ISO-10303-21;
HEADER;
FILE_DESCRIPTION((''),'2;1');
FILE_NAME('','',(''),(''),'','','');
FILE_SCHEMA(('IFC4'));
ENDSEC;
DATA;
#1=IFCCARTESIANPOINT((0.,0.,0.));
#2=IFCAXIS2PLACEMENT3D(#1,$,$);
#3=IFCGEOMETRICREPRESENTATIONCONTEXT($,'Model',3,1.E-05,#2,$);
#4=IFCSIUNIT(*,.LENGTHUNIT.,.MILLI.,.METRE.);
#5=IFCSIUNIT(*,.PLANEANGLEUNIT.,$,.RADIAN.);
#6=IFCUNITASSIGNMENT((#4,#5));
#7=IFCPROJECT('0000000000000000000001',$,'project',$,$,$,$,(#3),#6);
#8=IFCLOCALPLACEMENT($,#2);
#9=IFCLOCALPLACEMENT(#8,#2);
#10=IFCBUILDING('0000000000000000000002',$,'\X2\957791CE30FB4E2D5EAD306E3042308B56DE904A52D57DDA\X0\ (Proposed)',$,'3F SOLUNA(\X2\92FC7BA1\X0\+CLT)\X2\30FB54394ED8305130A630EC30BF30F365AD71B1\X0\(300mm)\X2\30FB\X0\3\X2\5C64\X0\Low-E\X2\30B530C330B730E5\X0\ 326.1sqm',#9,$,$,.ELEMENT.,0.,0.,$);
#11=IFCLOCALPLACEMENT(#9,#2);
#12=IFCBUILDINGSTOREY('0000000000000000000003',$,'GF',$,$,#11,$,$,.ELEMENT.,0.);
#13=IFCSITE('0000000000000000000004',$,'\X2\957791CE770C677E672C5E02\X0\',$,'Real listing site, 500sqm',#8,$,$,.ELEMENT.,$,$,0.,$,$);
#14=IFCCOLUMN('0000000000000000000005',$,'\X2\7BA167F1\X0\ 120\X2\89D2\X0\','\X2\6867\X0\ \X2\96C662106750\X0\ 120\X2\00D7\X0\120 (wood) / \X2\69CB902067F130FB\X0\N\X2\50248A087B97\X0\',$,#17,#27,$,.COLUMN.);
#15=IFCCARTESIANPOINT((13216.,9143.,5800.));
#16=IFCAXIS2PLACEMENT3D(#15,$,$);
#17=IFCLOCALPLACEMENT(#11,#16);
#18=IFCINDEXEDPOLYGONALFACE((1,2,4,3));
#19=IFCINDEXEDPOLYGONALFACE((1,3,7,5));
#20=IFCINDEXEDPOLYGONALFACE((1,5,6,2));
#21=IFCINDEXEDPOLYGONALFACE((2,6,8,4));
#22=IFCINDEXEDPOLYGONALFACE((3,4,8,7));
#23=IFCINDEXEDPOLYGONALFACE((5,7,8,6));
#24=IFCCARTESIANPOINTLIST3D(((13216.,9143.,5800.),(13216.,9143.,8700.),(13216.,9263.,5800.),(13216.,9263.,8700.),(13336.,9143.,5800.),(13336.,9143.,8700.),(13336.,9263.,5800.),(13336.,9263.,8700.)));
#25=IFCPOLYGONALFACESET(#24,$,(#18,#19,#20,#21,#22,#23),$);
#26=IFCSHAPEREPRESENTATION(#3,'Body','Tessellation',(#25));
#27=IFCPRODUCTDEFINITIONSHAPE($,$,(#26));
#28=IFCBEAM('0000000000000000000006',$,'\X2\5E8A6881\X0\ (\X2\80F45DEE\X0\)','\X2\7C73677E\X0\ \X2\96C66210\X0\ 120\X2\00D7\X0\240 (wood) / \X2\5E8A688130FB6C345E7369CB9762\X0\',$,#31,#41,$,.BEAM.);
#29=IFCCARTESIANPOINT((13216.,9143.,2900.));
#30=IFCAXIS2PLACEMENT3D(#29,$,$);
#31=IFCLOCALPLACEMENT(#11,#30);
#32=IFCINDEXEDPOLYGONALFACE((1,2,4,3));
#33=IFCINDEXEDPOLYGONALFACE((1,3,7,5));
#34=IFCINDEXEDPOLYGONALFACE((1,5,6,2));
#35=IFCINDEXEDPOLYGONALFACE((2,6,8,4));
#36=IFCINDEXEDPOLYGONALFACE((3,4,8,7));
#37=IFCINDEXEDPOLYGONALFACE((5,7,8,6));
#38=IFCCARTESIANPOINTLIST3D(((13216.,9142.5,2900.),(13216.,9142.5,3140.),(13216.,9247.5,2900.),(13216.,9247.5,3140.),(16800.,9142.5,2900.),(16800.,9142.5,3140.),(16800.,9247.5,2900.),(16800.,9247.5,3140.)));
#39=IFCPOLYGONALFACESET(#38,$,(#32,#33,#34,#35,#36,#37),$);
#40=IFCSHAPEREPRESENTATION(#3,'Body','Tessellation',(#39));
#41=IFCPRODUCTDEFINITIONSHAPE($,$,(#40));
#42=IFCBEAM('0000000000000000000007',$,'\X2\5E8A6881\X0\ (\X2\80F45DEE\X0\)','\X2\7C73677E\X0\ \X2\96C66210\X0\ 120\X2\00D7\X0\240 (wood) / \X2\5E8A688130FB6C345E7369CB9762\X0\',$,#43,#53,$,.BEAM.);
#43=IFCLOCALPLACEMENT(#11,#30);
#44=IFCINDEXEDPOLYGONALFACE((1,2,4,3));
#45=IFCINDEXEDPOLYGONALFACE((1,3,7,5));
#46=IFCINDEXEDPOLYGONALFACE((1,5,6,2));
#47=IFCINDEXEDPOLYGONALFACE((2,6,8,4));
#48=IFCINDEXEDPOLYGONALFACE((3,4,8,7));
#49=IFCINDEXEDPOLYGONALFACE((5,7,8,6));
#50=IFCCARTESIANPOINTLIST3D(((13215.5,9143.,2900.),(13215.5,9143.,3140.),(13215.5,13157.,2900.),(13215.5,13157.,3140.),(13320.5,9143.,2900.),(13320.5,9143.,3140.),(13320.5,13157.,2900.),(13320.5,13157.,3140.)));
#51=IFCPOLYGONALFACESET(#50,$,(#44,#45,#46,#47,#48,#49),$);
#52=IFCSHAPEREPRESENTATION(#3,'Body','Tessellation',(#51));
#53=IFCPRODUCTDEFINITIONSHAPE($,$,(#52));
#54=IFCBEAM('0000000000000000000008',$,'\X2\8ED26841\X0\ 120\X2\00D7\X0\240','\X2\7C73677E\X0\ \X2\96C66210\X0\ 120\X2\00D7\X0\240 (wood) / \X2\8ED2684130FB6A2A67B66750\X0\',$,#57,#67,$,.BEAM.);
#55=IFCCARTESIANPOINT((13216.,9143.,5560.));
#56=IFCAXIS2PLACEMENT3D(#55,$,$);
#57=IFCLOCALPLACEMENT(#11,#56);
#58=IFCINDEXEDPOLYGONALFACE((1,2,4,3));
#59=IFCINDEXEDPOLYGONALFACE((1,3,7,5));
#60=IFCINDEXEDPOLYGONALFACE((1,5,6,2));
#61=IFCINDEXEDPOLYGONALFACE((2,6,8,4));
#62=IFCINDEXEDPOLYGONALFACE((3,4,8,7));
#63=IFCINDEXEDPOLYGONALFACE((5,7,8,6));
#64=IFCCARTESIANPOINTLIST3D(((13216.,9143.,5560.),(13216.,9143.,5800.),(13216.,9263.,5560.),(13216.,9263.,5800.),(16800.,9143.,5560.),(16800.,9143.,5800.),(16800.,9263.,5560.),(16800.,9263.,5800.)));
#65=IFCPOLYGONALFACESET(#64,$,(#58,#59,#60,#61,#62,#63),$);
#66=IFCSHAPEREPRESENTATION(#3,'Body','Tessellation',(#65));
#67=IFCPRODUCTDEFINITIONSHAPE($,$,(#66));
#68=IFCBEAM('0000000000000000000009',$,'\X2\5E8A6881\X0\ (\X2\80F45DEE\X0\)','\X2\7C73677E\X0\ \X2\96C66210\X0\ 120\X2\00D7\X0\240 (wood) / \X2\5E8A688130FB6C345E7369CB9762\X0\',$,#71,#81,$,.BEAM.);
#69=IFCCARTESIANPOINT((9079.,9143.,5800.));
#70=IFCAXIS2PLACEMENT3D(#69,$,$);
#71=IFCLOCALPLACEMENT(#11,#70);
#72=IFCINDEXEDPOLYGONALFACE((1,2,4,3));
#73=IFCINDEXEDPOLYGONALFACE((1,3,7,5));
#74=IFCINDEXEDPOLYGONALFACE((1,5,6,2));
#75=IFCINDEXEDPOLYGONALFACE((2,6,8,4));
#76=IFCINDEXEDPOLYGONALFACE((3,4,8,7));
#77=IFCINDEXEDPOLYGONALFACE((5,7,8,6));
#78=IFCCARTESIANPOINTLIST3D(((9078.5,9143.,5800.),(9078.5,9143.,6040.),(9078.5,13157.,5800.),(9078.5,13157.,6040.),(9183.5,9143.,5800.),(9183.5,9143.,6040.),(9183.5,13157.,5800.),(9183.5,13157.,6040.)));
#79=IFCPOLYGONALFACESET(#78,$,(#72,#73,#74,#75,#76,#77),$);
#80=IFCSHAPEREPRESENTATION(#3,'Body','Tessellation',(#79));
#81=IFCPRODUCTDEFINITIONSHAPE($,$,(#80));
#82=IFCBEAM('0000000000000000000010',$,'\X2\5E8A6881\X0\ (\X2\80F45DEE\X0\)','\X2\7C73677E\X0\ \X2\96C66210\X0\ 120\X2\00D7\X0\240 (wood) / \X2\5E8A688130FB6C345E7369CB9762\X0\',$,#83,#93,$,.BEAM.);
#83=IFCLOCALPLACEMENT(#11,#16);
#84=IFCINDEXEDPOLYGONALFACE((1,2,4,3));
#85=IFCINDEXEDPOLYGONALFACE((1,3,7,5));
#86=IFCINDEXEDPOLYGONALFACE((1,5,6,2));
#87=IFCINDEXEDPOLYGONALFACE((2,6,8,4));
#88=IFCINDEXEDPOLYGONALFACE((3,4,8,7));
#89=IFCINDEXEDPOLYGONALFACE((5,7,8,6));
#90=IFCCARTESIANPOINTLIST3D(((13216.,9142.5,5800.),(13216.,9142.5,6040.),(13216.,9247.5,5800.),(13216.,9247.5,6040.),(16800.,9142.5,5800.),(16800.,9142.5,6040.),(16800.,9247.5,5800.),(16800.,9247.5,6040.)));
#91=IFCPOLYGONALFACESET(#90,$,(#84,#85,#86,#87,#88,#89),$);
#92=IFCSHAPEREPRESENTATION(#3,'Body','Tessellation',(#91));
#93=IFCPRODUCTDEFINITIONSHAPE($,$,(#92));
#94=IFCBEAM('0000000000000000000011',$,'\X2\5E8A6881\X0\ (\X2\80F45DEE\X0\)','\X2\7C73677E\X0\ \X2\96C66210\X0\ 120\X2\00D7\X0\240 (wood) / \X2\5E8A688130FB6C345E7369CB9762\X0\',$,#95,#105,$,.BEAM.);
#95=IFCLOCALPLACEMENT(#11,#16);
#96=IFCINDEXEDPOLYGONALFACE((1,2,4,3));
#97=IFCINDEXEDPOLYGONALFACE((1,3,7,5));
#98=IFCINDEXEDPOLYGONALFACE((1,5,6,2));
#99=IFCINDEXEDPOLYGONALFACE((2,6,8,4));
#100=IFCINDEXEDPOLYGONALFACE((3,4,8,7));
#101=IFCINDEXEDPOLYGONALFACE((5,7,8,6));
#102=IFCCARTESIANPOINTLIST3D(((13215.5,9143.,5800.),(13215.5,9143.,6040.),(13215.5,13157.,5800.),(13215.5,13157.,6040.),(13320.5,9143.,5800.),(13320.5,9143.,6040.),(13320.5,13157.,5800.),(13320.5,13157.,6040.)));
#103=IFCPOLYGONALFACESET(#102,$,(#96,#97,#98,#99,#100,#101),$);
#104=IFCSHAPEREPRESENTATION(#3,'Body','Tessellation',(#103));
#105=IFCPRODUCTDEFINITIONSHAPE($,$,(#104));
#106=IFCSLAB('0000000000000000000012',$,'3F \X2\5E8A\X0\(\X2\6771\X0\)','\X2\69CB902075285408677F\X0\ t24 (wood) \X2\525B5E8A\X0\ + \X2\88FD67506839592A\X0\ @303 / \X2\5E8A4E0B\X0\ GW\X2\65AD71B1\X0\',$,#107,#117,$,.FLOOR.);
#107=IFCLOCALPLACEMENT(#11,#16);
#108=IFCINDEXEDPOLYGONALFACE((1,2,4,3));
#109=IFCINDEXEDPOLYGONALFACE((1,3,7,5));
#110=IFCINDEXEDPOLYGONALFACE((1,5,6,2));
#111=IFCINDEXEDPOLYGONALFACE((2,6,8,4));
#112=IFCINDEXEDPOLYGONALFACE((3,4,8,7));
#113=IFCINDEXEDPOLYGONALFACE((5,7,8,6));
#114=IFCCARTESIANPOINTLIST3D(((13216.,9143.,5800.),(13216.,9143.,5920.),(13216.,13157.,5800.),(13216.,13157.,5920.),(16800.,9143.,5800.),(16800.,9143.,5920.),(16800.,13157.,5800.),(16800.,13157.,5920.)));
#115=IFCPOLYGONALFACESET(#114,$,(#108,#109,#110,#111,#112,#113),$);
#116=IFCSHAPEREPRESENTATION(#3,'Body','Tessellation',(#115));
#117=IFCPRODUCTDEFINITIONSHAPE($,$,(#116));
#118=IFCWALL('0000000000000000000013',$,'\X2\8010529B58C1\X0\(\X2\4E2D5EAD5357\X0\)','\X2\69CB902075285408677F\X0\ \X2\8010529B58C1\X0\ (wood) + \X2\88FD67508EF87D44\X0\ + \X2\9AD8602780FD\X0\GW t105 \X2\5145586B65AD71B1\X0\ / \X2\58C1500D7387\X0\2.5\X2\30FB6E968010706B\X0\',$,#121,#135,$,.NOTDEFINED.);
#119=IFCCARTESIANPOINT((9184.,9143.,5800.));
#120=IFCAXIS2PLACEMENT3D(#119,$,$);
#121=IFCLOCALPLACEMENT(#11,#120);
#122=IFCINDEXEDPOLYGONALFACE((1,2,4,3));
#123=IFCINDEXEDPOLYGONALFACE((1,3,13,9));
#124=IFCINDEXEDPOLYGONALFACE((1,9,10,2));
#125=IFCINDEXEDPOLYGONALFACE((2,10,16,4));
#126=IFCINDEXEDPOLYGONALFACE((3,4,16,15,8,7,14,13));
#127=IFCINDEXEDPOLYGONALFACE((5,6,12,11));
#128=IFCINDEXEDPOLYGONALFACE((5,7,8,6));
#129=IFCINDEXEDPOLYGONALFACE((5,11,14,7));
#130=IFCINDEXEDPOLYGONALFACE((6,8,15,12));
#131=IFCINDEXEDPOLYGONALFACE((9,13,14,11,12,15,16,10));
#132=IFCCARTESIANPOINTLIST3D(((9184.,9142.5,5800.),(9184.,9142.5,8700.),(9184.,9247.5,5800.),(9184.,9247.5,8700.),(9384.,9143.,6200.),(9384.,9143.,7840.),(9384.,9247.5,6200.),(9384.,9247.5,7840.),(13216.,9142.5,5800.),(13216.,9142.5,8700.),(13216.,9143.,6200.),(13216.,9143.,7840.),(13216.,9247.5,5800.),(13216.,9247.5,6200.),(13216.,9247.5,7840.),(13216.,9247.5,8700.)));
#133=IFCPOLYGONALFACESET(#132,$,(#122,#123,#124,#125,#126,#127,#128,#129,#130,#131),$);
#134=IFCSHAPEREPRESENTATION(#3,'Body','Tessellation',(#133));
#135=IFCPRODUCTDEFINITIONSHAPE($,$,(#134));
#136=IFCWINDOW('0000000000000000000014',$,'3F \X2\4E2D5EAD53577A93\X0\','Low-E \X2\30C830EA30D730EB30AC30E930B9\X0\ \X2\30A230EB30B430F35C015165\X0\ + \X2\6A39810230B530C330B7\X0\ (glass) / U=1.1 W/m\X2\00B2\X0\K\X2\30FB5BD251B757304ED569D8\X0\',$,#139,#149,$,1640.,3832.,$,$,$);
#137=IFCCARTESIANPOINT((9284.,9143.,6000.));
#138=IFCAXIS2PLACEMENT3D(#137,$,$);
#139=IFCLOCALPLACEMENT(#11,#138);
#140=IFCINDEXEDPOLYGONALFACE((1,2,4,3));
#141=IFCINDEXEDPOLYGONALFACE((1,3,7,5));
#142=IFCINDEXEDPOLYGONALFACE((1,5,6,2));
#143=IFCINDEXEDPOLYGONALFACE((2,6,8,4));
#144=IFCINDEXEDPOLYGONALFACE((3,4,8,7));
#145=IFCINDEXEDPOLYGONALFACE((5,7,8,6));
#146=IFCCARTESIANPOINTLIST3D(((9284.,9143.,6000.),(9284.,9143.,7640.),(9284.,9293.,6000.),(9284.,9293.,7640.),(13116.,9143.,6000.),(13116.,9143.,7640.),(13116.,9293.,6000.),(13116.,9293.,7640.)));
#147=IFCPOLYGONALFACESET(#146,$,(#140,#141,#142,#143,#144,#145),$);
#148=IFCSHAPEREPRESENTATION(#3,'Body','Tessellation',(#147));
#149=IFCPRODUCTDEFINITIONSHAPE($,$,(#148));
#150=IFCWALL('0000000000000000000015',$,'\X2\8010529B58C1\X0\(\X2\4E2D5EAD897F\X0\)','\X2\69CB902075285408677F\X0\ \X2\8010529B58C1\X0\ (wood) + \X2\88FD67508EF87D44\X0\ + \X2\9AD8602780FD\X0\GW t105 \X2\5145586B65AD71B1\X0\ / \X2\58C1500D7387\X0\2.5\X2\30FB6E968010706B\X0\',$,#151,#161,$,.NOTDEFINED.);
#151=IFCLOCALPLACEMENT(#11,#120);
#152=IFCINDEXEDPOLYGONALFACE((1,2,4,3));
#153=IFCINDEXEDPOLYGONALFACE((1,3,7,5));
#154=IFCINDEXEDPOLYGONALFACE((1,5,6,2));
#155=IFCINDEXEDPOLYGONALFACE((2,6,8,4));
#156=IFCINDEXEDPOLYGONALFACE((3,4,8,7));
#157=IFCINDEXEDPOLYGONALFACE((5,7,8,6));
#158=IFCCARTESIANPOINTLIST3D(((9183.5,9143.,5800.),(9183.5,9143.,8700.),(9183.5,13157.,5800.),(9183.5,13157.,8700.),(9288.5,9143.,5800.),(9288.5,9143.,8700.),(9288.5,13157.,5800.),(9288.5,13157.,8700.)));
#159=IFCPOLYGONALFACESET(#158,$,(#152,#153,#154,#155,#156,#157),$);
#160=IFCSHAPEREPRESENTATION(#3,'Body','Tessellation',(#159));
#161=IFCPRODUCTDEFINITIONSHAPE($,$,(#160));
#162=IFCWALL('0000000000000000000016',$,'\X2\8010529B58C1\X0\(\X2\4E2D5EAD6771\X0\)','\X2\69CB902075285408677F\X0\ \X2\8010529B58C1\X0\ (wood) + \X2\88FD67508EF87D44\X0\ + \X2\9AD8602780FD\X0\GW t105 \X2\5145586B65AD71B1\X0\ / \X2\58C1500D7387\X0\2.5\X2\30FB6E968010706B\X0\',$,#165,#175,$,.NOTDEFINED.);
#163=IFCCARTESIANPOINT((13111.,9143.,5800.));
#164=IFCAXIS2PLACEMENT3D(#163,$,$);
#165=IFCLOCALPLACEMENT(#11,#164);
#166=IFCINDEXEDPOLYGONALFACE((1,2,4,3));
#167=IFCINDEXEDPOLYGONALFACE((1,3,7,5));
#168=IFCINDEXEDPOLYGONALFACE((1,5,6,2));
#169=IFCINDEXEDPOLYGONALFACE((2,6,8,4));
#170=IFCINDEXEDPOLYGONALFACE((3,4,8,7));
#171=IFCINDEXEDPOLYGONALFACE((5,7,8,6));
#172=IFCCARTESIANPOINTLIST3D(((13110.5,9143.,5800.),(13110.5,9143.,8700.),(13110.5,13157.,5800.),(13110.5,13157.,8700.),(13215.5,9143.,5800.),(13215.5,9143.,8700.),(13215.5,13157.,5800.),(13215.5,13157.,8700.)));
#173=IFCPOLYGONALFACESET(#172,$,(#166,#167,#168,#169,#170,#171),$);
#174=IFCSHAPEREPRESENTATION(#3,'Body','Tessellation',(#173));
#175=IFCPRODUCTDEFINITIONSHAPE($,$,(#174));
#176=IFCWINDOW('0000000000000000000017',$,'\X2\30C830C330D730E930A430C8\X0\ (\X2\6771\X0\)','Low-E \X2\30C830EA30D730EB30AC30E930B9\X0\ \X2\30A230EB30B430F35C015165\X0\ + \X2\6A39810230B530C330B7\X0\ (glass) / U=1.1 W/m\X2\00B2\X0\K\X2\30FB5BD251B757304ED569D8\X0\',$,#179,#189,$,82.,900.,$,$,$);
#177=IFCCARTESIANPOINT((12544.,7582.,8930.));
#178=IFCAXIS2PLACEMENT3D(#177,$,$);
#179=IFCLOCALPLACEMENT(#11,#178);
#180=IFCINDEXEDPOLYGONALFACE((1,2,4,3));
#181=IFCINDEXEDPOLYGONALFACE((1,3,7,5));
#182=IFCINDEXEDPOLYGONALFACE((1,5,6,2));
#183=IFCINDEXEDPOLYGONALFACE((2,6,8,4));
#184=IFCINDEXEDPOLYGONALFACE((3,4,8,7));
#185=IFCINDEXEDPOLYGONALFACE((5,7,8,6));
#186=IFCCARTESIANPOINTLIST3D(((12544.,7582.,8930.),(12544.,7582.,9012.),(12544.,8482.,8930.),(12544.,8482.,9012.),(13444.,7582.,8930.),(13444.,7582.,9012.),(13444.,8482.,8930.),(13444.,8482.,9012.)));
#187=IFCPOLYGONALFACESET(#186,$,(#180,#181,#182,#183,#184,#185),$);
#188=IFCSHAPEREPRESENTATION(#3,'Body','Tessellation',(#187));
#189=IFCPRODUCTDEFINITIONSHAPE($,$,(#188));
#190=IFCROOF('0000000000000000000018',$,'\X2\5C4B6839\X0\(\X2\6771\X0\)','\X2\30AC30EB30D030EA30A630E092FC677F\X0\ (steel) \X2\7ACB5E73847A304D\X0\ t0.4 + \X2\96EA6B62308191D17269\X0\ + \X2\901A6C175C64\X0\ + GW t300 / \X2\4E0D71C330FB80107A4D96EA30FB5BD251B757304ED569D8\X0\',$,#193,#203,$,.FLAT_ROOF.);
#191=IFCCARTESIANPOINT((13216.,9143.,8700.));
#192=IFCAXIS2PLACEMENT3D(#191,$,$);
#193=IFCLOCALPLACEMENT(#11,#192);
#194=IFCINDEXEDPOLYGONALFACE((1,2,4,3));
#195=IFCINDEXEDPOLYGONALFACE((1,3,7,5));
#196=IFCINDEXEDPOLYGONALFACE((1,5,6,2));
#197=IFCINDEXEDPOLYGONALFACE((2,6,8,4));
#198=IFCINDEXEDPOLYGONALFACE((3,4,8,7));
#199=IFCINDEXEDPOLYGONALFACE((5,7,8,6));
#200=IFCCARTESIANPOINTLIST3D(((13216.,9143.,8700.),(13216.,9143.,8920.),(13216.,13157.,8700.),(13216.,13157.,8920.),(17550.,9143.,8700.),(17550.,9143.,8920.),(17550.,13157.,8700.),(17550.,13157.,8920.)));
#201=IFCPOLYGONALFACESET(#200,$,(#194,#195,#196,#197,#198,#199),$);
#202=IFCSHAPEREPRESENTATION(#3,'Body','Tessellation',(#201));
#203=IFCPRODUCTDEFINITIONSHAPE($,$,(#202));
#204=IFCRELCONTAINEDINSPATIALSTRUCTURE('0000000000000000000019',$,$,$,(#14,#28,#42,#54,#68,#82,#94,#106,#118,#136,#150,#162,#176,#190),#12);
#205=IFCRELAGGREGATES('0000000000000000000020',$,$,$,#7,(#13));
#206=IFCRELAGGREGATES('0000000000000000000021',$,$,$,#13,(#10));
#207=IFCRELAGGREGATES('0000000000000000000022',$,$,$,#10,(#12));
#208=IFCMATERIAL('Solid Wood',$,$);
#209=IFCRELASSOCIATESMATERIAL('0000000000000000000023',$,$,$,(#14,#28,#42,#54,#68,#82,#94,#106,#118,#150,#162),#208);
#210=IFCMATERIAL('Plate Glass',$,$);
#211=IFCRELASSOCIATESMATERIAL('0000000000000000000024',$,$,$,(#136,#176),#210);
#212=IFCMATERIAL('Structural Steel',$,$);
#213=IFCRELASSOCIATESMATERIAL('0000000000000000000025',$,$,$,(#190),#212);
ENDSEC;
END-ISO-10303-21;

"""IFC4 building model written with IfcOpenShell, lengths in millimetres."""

from ifc_helpers import new_model, si_unit, frame, frame_2d, origin, place, context, project, spatial, rectangle, extrude, material, element, fill, save


model = new_model("IFC4")

# Units and contexts
model_context = context("Model", 3, precision=1e-05, world=origin())
ifc_project = project(units=[si_unit("LENGTHUNIT", "METRE", prefix="MILLI"), si_unit("PLANEANGLEUNIT", "RADIAN")], contexts=[model_context])

# Site, building, storey
site_placement = place(None, origin())
site = spatial("IfcSite", under=ifc_project, at=site_placement, Name="長野県松本市", ObjectType="Real listing site, 500sqm", CompositionType="ELEMENT", RefElevation=0.0)
building_placement = place(site_placement, origin())
building = spatial("IfcBuilding", under=site, at=building_placement, Name="長野・中庭のある回遊動線 (Proposed)", ObjectType="3F SOLUNA(鋼管+CLT)・吹付けウレタン断熱(300mm)・3層Low-Eサッシュ 326.1sqm", CompositionType="ELEMENT", ElevationOfRefHeight=0.0, ElevationOfTerrain=0.0)
storey_placement = place(building_placement, origin())
storey = spatial("IfcBuildingStorey", under=building, at=storey_placement, Name="GF", CompositionType="ELEMENT", Elevation=0.0)

# Column
ifc_material_1 = material(Name="Solid Wood")
column_1_placement = place(storey_placement, frame((13216.0, 9143.0, 5800.0)))
element("IfcColumn", 1, at=column_1_placement, inside=storey, material=ifc_material_1, Name="管柱 120角", Description="桧 集成材 120×120 (wood) / 構造柱・N値計算", PredefinedType="COLUMN", context=model_context, shape_type="SweptSolid", body=[
    extrude(rectangle(XDim=120.0, YDim=120.0, at=frame_2d((60.0, 60.0))), frame((13216.0, 9143.0, 5800.0)), (0.0, 0.0, 1.0), 2900.0),
])

# Beams
beam_1_placement = place(storey_placement, frame((13216.0, 9143.0, 2900.0)))
element("IfcBeam", 2, at=beam_1_placement, inside=storey, material=ifc_material_1, Name="床梁 (胴差)", Description="米松 集成 120×240 (wood) / 床梁・水平構面", PredefinedType="BEAM", context=model_context, shape_type="SweptSolid", body=[
    extrude(rectangle(XDim=3584.0, YDim=105.0, at=frame_2d((1792.0, 52.0))), frame((13216.0, 9143.0, 2900.0)), (0.0, 0.0, 1.0), 240.0),
])
beam_2_placement = place(storey_placement, frame((13216.0, 9143.0, 2900.0)))
element("IfcBeam", 3, at=beam_2_placement, inside=storey, material=ifc_material_1, Name="床梁 (胴差)", Description="米松 集成 120×240 (wood) / 床梁・水平構面", PredefinedType="BEAM", context=model_context, shape_type="SweptSolid", body=[
    extrude(rectangle(XDim=105.0, YDim=4014.0, at=frame_2d((52.0, 2007.0))), frame((13216.0, 9143.0, 2900.0)), (0.0, 0.0, 1.0), 240.0),
])
beam_3_placement = place(storey_placement, frame((13216.0, 9143.0, 5560.0)))
element("IfcBeam", 4, at=beam_3_placement, inside=storey, material=ifc_material_1, Name="軒桁 120×240", Description="米松 集成 120×240 (wood) / 軒桁・横架材", PredefinedType="BEAM", context=model_context, shape_type="SweptSolid", body=[
    extrude(rectangle(XDim=3584.0, YDim=120.0, at=frame_2d((1792.0, 60.0))), frame((13216.0, 9143.0, 5560.0)), (0.0, 0.0, 1.0), 240.0),
])
beam_4_placement = place(storey_placement, frame((9079.0, 9143.0, 5800.0)))
element("IfcBeam", 5, at=beam_4_placement, inside=storey, material=ifc_material_1, Name="床梁 (胴差)", Description="米松 集成 120×240 (wood) / 床梁・水平構面", PredefinedType="BEAM", context=model_context, shape_type="SweptSolid", body=[
    extrude(rectangle(XDim=105.0, YDim=4014.0, at=frame_2d((52.0, 2007.0))), frame((9079.0, 9143.0, 5800.0)), (0.0, 0.0, 1.0), 240.0),
])
beam_5_placement = place(storey_placement, frame((13216.0, 9143.0, 5800.0)))
element("IfcBeam", 6, at=beam_5_placement, inside=storey, material=ifc_material_1, Name="床梁 (胴差)", Description="米松 集成 120×240 (wood) / 床梁・水平構面", PredefinedType="BEAM", context=model_context, shape_type="SweptSolid", body=[
    extrude(rectangle(XDim=3584.0, YDim=105.0, at=frame_2d((1792.0, 52.0))), frame((13216.0, 9143.0, 5800.0)), (0.0, 0.0, 1.0), 240.0),
])
beam_6_placement = place(storey_placement, frame((13216.0, 9143.0, 5800.0)))
element("IfcBeam", 7, at=beam_6_placement, inside=storey, material=ifc_material_1, Name="床梁 (胴差)", Description="米松 集成 120×240 (wood) / 床梁・水平構面", PredefinedType="BEAM", context=model_context, shape_type="SweptSolid", body=[
    extrude(rectangle(XDim=105.0, YDim=4014.0, at=frame_2d((52.0, 2007.0))), frame((13216.0, 9143.0, 5800.0)), (0.0, 0.0, 1.0), 240.0),
])

# Slab
slab_placement = place(storey_placement, frame((13216.0, 9143.0, 5800.0)))
element("IfcSlab", 8, at=slab_placement, inside=storey, material=ifc_material_1, Name="3F 床(東)", Description="構造用合板 t24 (wood) 剛床 + 製材根太 @303 / 床下 GW断熱", PredefinedType="FLOOR", context=model_context, shape_type="SweptSolid", body=[
    extrude(rectangle(XDim=3584.0, YDim=4014.0, at=frame_2d((1792.0, 2007.0))), frame((13216.0, 9143.0, 5800.0)), (0.0, 0.0, 1.0), 120.0),
])

# Wall, opening, window
wall_1_placement = place(storey_placement, frame((9184.0, 9143.0, 5800.0)))
wall_1 = element("IfcWall", 9, at=wall_1_placement, inside=storey, material=ifc_material_1, Name="耐力壁(中庭南)", Description="構造用合板 耐力壁 (wood) + 製材軸組 + 高性能GW t105 充填断熱 / 壁倍率2.5・準耐火", PredefinedType="NOTDEFINED", context=model_context, shape_type="SweptSolid", body=[
    extrude(rectangle(XDim=4032.0, YDim=105.0, at=frame_2d((2016.0, 52.0))), frame((9184.0, 9143.0, 5800.0)), (0.0, 0.0, 1.0), 2900.0),
])
opening_placement = place(storey_placement, frame((9284.0, 9143.0, 6000.0)))
opening = element("IfcOpeningElement", 10, at=opening_placement, cuts=wall_1, PredefinedType="NOTDEFINED", context=model_context, shape_type="SweptSolid", body=[
    extrude(rectangle(XDim=3832.0, YDim=150.0, at=frame_2d((1916.0, 75.0))), frame((9284.0, 9143.0, 6000.0)), (0.0, 0.0, 1.0), 1640.0),
])
ifc_material_2 = material(Name="Plate Glass")
window_1_placement = place(storey_placement, frame((9284.0, 9143.0, 6000.0)))
window_1 = element("IfcWindow", 11, at=window_1_placement, inside=storey, material=ifc_material_2, Name="3F 中庭南窓", Description="Low-E トリプルガラス アルゴン封入 + 樹脂サッシ (glass) / U=1.1 W/m²K・寒冷地仕様", OverallHeight=1640.0, OverallWidth=3832.0, context=model_context, shape_type="SweptSolid", body=[
    extrude(rectangle(XDim=3832.0, YDim=150.0, at=frame_2d((1916.0, 75.0))), frame((9284.0, 9143.0, 6000.0)), (0.0, 0.0, 1.0), 1640.0),
])
fill(opening, window_1)

# Walls
wall_2_placement = place(storey_placement, frame((9184.0, 9143.0, 5800.0)))
element("IfcWall", 12, at=wall_2_placement, inside=storey, material=ifc_material_1, Name="耐力壁(中庭西)", Description="構造用合板 耐力壁 (wood) + 製材軸組 + 高性能GW t105 充填断熱 / 壁倍率2.5・準耐火", PredefinedType="NOTDEFINED", context=model_context, shape_type="SweptSolid", body=[
    extrude(rectangle(XDim=105.0, YDim=4014.0, at=frame_2d((52.0, 2007.0))), frame((9184.0, 9143.0, 5800.0)), (0.0, 0.0, 1.0), 2900.0),
])
wall_3_placement = place(storey_placement, frame((13111.0, 9143.0, 5800.0)))
element("IfcWall", 13, at=wall_3_placement, inside=storey, material=ifc_material_1, Name="耐力壁(中庭東)", Description="構造用合板 耐力壁 (wood) + 製材軸組 + 高性能GW t105 充填断熱 / 壁倍率2.5・準耐火", PredefinedType="NOTDEFINED", context=model_context, shape_type="SweptSolid", body=[
    extrude(rectangle(XDim=105.0, YDim=4014.0, at=frame_2d((52.0, 2007.0))), frame((13111.0, 9143.0, 5800.0)), (0.0, 0.0, 1.0), 2900.0),
])

# Window
window_2_placement = place(storey_placement, frame((12544.0, 7582.0, 8930.0)))
element("IfcWindow", 14, at=window_2_placement, inside=storey, material=ifc_material_2, Name="トップライト (東)", Description="Low-E トリプルガラス アルゴン封入 + 樹脂サッシ (glass) / U=1.1 W/m²K・寒冷地仕様", OverallHeight=82.0, OverallWidth=900.0, context=model_context, shape_type="SweptSolid", body=[
    extrude(rectangle(XDim=900.0, YDim=900.0, at=frame_2d((450.0, 450.0))), frame((12544.0, 7582.0, 8930.0)), (0.0, 0.0, 1.0), 82.0),
])

# Roof
ifc_material_3 = material(Name="Structural Steel")
for number, where, name in (
    (15, (13216.0, 9143.0, 8700.0), "屋根(東)"),
):
    element("IfcRoof", number, at=place(storey_placement, frame(where)), inside=storey, material=ifc_material_3, Name=name, Description="ガルバリウム鋼板 (steel) 立平葺き t0.4 + 雪止め金物 + 通気層 + GW t300 / 不燃・耐積雪・寒冷地仕様", PredefinedType="FLAT_ROOF", context=model_context, shape_type="SweptSolid", body=[
        extrude(rectangle(XDim=4334.0, YDim=4014.0, at=frame_2d((2167.0, 2007.0))), frame((13216.0, 9143.0, 8700.0)), (0.0, 0.0, 1.0), 220.0),
    ])

save(model, "model.ifc")
